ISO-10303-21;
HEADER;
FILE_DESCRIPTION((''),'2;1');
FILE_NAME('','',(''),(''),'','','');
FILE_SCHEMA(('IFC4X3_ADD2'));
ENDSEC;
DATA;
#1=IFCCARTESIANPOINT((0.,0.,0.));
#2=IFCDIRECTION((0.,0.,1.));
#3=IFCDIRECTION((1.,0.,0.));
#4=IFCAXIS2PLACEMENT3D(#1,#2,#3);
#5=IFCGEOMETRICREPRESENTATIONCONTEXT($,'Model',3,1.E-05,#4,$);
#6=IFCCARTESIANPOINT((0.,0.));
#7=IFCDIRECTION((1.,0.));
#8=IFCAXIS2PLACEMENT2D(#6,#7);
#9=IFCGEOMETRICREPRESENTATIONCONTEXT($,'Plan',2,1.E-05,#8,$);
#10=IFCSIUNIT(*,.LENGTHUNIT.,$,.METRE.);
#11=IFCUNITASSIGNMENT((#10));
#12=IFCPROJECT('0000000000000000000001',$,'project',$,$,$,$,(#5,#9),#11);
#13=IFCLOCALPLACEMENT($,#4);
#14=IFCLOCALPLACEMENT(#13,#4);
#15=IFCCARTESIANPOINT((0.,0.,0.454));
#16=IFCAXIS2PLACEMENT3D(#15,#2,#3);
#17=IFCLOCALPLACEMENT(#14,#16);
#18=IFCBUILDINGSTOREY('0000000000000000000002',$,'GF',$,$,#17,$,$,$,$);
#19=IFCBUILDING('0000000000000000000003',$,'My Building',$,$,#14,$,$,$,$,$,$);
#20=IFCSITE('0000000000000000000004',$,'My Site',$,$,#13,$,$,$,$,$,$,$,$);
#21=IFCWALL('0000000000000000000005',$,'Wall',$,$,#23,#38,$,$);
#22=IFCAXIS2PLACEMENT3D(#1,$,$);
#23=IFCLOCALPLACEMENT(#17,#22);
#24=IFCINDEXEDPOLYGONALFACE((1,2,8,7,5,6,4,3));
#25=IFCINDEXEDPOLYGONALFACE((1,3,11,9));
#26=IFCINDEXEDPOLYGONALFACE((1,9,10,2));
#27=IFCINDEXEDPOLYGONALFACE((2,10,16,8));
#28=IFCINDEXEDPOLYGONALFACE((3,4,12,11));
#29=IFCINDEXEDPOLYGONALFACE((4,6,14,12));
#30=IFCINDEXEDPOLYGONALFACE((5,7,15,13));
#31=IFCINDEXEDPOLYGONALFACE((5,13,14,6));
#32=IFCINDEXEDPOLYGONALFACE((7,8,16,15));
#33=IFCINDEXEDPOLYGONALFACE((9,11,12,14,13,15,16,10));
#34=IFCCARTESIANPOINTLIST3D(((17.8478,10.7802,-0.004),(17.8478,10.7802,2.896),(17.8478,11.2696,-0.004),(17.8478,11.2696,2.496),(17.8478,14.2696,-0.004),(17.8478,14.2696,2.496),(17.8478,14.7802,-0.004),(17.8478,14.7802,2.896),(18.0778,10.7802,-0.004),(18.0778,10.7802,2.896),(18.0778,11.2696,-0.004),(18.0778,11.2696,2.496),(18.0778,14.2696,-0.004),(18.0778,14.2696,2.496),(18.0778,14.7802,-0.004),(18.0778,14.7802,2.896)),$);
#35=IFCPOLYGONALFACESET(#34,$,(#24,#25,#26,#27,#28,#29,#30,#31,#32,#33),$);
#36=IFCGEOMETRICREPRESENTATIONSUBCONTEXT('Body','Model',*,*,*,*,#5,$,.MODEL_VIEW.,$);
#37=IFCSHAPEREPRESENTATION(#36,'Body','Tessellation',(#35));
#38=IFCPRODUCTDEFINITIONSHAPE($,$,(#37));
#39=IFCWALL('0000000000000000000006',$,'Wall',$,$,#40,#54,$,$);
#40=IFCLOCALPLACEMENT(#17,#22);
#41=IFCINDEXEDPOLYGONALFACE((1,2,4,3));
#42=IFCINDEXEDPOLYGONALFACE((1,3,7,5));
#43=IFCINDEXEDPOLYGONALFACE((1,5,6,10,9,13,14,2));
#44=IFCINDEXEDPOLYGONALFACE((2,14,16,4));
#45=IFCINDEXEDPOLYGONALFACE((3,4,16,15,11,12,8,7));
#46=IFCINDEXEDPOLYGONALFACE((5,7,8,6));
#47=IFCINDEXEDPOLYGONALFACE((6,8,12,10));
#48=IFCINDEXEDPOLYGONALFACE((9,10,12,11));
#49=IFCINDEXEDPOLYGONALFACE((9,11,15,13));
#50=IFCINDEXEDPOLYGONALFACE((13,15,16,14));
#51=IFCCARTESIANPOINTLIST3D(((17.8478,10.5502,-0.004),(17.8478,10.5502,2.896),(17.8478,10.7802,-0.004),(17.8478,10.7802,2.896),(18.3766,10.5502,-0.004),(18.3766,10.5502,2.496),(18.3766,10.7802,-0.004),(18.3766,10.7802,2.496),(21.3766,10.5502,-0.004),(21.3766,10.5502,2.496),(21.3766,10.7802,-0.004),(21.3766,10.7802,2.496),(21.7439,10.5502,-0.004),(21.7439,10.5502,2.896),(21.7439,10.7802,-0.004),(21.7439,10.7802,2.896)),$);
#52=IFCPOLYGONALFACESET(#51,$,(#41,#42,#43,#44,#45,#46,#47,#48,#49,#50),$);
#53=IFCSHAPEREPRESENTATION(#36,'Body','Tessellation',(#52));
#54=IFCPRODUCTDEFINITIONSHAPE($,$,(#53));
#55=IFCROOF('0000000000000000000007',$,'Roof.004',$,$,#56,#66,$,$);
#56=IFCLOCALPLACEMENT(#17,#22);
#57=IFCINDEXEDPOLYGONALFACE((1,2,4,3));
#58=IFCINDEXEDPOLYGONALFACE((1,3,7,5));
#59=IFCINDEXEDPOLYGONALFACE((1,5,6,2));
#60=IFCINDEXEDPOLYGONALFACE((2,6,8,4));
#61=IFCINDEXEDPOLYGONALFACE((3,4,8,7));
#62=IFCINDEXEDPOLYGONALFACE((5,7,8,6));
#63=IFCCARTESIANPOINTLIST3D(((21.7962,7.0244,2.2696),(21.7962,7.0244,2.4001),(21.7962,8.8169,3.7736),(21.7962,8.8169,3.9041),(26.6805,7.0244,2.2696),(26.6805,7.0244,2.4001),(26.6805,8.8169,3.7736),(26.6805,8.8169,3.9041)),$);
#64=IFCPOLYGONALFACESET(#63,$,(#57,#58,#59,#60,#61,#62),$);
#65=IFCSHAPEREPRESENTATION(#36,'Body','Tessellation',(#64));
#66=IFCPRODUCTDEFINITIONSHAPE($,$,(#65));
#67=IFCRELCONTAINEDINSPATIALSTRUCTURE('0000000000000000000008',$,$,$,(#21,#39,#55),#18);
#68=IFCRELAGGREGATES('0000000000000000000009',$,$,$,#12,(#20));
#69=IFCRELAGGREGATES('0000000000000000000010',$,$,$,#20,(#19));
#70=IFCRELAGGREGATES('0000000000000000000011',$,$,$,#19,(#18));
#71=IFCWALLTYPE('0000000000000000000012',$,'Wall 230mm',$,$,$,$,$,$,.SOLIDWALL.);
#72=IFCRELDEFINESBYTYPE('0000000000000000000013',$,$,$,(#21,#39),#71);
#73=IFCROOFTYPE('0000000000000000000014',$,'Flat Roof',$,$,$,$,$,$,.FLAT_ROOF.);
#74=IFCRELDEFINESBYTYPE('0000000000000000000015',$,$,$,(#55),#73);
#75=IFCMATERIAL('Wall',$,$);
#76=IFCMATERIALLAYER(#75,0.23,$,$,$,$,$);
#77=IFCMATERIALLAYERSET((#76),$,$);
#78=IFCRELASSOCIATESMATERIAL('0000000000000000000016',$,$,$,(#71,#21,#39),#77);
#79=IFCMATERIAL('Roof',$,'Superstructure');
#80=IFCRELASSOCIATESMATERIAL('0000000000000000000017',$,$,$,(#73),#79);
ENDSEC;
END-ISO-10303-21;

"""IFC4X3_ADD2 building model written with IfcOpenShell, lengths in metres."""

from ifc_helpers import new_model, si_unit, frame, origin_with_axes, origin_2d_with_axis, place, context, subcontext, project, spatial, polyline, line, indexed_curve, outline, extrude, source, transform, mapped, material, layer, layer_set, layer_usage, type_object, element, save


model = new_model("IFC4X3_ADD2")

# Units and contexts
model_context = context("Model", 3, precision=1e-05, world=origin_with_axes())
plan_context = context("Plan", 2, precision=1e-05, world=origin_2d_with_axis())
body_context = subcontext(model_context, "Body", "Model", "MODEL_VIEW")
ifc_project = project(units=[si_unit("LENGTHUNIT", "METRE")], contexts=[model_context, plan_context])

# Site, building, storey
site_placement = place(None, origin_with_axes())
site = spatial("IfcSite", under=ifc_project, at=site_placement, Name="My Site")
building_placement = place(site_placement, origin_with_axes())
building = spatial("IfcBuilding", under=site, at=building_placement, Name="My Building")
storey_placement = place(building_placement, frame((0.0, 0.0, 0.454), z_axis=(0.0, 0.0, 1.0), x_axis=(1.0, 0.0, 0.0)))
storey = spatial("IfcBuildingStorey", under=building, at=storey_placement, Name="GF")

# Walls, openings
ifc_material_1 = material(Name="Wall")
ifc_layer_1 = layer(ifc_material_1, 0.23)
ifc_layer_set_1 = layer_set([ifc_layer_1])
ifc_layer_usage_1 = layer_usage(ifc_layer_set_1, "AXIS2", "POSITIVE", 0.0)
wall_type = type_object("IfcWallType", Name="Wall 230mm", PredefinedType="SOLIDWALL", material=ifc_layer_set_1)
wall_1_placement = place(storey_placement, frame((18.0778, 10.7802, -0.004), z_axis=(0.0, 0.0, 1.0), x_axis=(0.000001, 1.0, 0.0)))
wall_1 = element("IfcWall", 1, at=wall_1_placement, inside=storey, type_object=wall_type, material=ifc_layer_usage_1, Name="Wall", context=body_context, shape_type="SweptSolid", body=[
    extrude(outline(indexed_curve([(0.0, 0.0), (0.0, 0.23), (4.0, 0.23), (4.0, 0.0), (0.0, 0.0)], self_intersect=False)), origin_with_axes(), (0.0, 0.0, 1.0), 2.9),
])
shared_shape = source(origin_with_axes(), body_context, "Body", "SweptSolid", [
    extrude(outline(indexed_curve([(0.0, 0.0), (3.0, 0.0), (3.0, 2.5), (0.0, 2.5)], segments=[line(1, 2, 3, 4, 1)])), frame((0.0, -0.6, 0.0), z_axis=(0.0, -1.0, 0.0), x_axis=(1.0, 0.0, 0.0)), (0.0, 0.0, -1.0), 1.2),
])
opening_1_placement = place(wall_1_placement, frame((0.4894, 0.0, 0.0), z_axis=(0.0, 0.0, 1.0), x_axis=(1.0, 0.0, 0.0)))
element("IfcOpeningElement", 2, at=opening_1_placement, cuts=wall_1, PredefinedType="OPENING", context=body_context, shape_type="MappedRepresentation", body=[
    mapped(shared_shape, transform((0.0, 0.0, 0.0), x_axis=(1.0, 0.0, 0.0), y_axis=(0.0, 1.0, 0.0), z_axis=(0.0, 0.0, 1.0), scale=1.0)),
])
ifc_layer_usage_2 = layer_usage(ifc_layer_set_1, "AXIS2", "POSITIVE", 0.0)
wall_2_placement = place(storey_placement, frame((21.7439, 10.7802, -0.004), z_axis=(0.0, 0.0, 1.0), x_axis=(-1.0, 0.0, 0.0)))
wall_2 = element("IfcWall", 3, at=wall_2_placement, inside=storey, type_object=wall_type, material=ifc_layer_usage_2, Name="Wall", context=body_context, shape_type="SweptSolid", body=[
    extrude(outline(indexed_curve([(0.0, 0.0), (0.0, 0.23), (3.8962, 0.23), (3.8962, 0.0), (0.0, 0.0)], self_intersect=False)), origin_with_axes(), (0.0, 0.0, 1.0), 2.9),
])
opening_2_placement = place(wall_2_placement, frame((0.3674, 0.0, 0.0), z_axis=(0.0, 0.0, 1.0), x_axis=(1.0, 0.0, 0.0)))
element("IfcOpeningElement", 4, at=opening_2_placement, cuts=wall_2, PredefinedType="OPENING", context=body_context, shape_type="MappedRepresentation", body=[
    mapped(shared_shape, transform((0.0, 0.0, 0.0), x_axis=(1.0, 0.0, 0.0), y_axis=(0.0, 1.0, 0.0), z_axis=(0.0, 0.0, 1.0), scale=1.0)),
])

# Roof
ifc_material_2 = material(Name="Roof", Category="Superstructure")
roof_type = type_object("IfcRoofType", Name="Flat Roof", PredefinedType="FLAT_ROOF", material=ifc_material_2)
roof_placement = place(storey_placement, frame((21.7962, 8.0241, 3.1084), z_axis=(0.0, -0.642788, 0.766044), x_axis=(1.0, 0.0, 0.0)))
element("IfcRoof", 5, at=roof_placement, inside=storey, type_object=roof_type, Name="Roof.004", context=body_context, shape_type="SweptSolid", body=[
    extrude(outline(polyline([(-2.4421, -0.0653), (2.4421, -0.0653), (2.4421, 0.0653), (-2.4421, 0.0653), (-2.4421, -0.0653)])), frame((2.4421, 1.0768, 0.05), z_axis=(0.0, 0.766044, -0.642788), x_axis=(1.0, 0.0, 0.0)), (0.0, 0.642788, -0.766044), 2.3398),
])

save(model, "model.ifc")
